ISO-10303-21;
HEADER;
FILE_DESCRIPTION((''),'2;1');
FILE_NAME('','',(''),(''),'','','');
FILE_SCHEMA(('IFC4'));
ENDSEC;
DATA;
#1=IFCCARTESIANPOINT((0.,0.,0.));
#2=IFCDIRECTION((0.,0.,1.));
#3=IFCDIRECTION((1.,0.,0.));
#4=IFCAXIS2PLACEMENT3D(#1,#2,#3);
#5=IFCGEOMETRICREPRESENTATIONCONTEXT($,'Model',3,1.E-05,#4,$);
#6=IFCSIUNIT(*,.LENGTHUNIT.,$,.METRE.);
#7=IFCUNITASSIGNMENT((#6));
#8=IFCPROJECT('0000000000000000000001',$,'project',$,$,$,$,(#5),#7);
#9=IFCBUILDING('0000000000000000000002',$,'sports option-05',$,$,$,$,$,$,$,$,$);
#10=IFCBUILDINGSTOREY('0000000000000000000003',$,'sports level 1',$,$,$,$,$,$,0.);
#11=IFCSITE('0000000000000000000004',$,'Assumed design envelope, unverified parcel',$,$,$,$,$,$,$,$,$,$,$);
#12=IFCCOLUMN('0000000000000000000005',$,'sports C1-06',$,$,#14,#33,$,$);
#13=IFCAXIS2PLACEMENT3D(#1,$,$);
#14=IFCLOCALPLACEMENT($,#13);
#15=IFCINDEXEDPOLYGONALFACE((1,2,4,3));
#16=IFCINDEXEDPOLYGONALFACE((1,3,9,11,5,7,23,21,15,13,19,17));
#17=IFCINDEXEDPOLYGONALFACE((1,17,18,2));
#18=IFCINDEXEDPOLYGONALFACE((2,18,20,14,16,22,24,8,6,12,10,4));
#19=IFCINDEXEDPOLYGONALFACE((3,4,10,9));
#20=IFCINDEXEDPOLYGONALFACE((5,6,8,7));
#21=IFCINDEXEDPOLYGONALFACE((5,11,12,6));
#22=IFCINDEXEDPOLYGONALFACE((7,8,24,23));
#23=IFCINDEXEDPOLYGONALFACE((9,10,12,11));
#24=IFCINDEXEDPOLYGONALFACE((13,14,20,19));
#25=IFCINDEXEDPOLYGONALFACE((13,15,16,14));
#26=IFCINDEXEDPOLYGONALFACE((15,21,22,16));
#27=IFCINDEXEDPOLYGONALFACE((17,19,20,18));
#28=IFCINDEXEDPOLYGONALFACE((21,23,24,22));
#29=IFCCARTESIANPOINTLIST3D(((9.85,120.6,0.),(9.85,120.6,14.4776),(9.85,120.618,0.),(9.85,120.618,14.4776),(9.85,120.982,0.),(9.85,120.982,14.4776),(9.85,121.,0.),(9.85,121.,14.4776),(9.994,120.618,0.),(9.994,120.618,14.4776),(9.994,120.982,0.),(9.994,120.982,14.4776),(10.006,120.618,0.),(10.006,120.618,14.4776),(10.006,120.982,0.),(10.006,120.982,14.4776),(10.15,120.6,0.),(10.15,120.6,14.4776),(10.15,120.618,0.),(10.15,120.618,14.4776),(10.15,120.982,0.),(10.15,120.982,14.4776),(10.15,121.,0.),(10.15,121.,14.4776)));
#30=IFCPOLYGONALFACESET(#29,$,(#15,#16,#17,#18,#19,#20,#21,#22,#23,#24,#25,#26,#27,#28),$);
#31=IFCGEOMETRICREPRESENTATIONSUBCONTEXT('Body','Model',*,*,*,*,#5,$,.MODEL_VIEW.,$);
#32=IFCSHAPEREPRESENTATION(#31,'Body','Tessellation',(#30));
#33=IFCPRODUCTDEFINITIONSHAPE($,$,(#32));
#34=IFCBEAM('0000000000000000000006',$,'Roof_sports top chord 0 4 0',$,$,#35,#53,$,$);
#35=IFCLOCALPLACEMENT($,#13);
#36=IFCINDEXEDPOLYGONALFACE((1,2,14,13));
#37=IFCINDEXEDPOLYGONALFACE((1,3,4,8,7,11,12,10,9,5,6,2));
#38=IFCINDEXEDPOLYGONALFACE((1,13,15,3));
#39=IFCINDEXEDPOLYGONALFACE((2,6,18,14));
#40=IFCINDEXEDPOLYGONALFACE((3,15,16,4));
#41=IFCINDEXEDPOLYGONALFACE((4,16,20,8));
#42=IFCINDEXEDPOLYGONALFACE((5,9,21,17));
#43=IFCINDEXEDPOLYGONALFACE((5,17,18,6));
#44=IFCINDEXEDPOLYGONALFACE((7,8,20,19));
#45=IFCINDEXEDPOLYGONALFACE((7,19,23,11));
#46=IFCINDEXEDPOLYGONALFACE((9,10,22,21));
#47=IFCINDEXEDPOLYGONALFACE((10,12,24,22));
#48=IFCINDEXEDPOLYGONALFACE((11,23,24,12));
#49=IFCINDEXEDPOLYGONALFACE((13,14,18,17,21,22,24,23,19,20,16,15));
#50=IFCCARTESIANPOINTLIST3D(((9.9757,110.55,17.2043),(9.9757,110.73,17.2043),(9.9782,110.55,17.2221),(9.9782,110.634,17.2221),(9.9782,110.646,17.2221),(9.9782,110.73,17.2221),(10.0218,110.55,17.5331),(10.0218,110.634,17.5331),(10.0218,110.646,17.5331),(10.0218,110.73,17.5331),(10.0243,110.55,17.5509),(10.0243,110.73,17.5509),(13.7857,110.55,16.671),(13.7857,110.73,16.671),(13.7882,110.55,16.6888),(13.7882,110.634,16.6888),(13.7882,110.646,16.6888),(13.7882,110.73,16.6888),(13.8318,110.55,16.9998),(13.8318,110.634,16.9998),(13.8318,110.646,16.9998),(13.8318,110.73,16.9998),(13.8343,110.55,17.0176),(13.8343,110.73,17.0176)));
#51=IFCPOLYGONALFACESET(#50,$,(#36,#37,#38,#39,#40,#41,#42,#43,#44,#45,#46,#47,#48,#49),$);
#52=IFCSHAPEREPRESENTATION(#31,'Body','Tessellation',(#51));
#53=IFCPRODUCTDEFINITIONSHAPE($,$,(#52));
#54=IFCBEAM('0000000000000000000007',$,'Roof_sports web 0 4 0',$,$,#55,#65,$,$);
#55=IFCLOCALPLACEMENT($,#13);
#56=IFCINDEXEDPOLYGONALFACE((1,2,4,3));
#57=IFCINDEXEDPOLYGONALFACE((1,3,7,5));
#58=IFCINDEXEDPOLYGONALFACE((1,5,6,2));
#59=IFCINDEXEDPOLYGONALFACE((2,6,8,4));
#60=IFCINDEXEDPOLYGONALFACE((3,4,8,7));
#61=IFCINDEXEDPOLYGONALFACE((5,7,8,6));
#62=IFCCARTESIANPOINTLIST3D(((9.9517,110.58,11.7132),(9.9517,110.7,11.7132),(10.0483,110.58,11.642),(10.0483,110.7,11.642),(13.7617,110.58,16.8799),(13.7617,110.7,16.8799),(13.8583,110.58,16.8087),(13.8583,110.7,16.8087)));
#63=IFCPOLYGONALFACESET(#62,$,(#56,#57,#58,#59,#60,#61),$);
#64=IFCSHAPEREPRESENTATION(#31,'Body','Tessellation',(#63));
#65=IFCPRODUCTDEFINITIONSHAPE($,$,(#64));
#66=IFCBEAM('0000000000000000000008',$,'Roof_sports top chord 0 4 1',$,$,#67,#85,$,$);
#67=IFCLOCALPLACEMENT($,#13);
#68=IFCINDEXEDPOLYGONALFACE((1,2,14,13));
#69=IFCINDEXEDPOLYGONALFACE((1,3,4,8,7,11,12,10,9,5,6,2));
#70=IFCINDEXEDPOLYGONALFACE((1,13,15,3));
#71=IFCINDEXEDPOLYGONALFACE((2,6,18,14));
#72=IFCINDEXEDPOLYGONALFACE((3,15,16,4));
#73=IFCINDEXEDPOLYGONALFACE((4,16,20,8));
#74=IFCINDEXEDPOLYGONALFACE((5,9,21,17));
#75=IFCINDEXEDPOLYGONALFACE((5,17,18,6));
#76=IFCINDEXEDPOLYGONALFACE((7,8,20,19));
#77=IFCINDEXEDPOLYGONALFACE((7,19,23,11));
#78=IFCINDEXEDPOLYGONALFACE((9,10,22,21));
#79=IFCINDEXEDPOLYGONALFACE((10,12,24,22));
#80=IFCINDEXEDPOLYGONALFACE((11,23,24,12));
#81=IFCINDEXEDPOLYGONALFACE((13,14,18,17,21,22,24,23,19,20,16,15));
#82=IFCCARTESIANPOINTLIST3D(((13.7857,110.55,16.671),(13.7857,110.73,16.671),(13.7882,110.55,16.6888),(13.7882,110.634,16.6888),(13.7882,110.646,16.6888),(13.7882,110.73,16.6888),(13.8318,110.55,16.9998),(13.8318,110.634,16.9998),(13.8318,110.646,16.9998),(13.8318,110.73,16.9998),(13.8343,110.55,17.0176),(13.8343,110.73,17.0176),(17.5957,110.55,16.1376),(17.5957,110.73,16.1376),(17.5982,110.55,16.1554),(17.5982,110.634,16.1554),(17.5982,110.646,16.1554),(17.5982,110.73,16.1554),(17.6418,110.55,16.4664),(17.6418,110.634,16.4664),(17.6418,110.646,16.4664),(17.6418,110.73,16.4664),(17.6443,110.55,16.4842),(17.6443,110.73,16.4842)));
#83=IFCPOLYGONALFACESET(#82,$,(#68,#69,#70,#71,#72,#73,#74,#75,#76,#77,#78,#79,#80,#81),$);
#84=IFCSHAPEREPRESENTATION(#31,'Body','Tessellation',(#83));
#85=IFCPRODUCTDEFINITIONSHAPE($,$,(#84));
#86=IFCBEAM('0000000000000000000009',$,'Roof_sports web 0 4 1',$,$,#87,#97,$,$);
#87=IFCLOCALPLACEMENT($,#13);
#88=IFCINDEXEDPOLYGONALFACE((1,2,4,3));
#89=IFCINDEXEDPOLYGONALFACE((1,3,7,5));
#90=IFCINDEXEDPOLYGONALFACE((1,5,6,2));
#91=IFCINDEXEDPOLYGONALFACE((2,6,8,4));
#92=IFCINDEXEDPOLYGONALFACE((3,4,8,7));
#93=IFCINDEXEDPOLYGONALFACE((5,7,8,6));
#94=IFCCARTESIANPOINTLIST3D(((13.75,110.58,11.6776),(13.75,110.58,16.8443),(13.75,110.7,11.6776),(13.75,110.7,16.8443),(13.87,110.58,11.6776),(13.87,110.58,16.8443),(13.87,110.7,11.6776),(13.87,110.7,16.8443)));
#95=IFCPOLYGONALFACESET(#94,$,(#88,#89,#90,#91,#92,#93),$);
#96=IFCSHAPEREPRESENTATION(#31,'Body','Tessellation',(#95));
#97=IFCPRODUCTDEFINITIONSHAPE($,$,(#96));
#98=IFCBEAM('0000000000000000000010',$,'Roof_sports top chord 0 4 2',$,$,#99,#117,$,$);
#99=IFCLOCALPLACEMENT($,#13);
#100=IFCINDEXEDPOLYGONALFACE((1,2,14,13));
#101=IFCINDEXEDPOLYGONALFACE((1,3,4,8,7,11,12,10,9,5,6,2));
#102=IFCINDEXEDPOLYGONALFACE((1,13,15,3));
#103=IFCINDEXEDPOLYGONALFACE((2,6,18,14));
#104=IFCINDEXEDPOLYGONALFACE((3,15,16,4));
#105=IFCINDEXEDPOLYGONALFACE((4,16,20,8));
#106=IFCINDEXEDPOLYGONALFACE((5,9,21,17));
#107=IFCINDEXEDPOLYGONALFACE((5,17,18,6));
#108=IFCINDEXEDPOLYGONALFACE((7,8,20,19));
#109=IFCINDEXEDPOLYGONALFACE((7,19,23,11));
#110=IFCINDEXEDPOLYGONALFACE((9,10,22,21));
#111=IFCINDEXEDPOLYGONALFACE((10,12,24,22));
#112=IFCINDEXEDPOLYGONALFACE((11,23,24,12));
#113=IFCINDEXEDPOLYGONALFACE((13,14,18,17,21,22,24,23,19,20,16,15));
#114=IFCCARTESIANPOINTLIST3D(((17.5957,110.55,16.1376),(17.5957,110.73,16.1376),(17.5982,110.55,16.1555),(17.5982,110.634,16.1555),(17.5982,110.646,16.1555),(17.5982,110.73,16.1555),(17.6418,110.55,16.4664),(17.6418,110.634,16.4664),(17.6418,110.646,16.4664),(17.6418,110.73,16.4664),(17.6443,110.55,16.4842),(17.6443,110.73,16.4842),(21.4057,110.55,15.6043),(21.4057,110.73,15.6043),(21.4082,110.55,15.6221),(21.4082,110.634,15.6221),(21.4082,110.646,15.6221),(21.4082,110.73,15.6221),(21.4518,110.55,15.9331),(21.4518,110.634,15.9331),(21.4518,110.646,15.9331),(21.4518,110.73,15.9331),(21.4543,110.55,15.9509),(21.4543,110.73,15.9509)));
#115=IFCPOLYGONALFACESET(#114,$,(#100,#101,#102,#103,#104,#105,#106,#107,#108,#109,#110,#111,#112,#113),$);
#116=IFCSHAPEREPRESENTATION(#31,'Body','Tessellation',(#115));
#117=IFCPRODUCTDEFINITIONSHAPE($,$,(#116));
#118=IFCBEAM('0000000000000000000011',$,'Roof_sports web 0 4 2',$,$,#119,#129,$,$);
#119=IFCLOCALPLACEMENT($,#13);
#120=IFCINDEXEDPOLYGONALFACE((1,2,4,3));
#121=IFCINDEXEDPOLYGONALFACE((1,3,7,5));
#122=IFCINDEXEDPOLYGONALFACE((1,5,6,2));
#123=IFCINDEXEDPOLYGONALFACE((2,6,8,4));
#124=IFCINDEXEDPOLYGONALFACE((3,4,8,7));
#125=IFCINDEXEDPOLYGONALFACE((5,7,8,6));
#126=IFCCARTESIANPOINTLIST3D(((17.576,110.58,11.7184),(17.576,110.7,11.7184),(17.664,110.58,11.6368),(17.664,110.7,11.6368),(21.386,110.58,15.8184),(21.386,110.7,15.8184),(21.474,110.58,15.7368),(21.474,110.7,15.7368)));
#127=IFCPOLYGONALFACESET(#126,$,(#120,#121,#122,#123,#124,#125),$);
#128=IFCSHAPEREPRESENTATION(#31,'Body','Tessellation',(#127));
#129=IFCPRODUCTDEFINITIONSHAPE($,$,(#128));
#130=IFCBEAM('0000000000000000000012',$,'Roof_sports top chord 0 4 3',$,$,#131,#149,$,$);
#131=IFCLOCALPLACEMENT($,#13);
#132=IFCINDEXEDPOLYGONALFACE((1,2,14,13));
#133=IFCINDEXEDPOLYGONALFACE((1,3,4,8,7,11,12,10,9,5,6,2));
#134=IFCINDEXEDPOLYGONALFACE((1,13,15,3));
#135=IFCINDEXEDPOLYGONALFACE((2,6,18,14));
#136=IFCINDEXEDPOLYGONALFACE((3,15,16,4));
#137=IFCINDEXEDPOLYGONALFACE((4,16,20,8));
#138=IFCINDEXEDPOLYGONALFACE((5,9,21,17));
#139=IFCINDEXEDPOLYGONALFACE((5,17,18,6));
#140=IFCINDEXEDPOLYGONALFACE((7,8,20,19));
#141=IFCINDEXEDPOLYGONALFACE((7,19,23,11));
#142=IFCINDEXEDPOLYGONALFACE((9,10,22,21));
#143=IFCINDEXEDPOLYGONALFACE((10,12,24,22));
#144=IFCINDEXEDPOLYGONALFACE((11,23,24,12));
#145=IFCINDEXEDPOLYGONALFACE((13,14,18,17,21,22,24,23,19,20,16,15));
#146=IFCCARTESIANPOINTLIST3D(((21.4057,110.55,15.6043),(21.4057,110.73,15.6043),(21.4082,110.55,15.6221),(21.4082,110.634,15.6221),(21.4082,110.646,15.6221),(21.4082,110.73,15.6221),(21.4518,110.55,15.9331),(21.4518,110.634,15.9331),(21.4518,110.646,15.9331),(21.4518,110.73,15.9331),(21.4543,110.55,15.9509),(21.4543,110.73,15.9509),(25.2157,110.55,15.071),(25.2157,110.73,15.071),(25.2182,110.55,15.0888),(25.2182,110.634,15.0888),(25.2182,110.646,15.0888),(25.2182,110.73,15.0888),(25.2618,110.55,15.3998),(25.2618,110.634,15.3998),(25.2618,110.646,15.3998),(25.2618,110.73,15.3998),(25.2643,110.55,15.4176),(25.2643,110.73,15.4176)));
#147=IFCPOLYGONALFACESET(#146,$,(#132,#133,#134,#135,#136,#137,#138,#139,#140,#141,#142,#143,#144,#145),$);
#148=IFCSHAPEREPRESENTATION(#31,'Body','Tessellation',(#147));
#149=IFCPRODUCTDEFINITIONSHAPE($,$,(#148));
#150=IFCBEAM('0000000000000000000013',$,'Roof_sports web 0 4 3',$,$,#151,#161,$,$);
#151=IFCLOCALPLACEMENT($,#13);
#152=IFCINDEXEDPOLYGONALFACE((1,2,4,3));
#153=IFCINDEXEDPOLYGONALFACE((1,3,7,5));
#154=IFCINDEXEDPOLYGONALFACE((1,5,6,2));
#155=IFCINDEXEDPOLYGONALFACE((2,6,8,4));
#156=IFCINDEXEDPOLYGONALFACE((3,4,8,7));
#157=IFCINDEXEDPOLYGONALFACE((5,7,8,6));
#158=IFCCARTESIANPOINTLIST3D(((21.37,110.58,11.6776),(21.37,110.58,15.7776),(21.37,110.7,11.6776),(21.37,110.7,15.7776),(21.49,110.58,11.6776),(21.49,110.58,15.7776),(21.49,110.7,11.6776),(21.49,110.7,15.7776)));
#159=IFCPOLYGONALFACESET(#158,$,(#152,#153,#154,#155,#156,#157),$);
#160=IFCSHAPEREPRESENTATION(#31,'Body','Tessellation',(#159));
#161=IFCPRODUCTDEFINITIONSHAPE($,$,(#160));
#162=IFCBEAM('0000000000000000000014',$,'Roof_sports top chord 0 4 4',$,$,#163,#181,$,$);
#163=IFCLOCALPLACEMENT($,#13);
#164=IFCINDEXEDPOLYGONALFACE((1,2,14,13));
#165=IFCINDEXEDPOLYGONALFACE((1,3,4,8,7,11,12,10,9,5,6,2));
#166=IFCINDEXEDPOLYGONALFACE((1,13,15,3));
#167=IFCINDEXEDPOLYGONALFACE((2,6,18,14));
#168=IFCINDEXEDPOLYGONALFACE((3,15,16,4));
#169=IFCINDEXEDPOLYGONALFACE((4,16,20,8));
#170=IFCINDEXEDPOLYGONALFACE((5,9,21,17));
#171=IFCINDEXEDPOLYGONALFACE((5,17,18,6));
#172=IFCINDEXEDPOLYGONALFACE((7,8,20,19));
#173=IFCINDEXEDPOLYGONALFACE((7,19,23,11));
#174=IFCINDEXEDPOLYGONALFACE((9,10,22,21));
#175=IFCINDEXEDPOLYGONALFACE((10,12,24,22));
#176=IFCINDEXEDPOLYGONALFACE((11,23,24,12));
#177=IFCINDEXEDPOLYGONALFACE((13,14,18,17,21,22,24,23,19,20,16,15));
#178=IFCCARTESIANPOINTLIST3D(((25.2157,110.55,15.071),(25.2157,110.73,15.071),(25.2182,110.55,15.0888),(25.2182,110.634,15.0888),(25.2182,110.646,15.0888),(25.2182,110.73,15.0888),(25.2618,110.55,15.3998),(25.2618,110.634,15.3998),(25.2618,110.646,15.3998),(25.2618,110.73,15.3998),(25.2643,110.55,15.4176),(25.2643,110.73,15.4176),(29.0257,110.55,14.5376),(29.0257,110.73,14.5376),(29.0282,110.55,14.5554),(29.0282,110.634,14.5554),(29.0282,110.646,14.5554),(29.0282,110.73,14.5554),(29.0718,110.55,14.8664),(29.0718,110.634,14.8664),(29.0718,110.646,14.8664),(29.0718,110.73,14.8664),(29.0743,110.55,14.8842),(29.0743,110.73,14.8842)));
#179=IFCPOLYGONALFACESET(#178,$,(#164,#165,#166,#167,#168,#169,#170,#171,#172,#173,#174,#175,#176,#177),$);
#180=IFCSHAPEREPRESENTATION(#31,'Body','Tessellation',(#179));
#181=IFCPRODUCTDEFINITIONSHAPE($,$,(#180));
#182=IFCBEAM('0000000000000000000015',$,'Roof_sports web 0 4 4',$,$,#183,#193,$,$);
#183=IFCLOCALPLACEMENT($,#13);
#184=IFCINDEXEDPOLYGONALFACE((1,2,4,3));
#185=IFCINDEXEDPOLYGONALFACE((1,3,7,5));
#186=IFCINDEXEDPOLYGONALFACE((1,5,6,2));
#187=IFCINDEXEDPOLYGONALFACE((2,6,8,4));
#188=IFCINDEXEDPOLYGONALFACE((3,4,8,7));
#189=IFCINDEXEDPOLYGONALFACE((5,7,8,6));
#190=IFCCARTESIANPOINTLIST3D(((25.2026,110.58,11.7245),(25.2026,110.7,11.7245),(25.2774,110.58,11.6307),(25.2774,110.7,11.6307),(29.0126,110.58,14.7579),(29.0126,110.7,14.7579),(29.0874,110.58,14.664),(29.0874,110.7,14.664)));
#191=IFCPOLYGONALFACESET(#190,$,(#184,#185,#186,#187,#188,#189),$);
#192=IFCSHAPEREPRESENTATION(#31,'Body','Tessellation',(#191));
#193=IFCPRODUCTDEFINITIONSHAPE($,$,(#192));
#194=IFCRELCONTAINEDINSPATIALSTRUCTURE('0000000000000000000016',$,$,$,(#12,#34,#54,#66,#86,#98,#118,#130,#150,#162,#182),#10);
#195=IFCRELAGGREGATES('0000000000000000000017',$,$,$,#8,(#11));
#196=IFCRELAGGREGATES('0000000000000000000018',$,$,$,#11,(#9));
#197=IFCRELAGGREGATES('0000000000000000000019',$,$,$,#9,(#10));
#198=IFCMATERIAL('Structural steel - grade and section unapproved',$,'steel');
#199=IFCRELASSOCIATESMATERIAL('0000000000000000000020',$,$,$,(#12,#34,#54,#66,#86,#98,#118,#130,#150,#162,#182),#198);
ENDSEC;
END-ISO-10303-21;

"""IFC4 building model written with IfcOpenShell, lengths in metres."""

from ifc_helpers import new_model, si_unit, frame, origin_with_axes, place, context, subcontext, project, spatial, rectangle, i_section, extrude, material, element, save


model = new_model("IFC4")

# Units and contexts
model_context = context("Model", 3, precision=1e-05, world=origin_with_axes())
body_context = subcontext(model_context, "Body", "Model", "MODEL_VIEW")
ifc_project = project(units=[si_unit("LENGTHUNIT", "METRE")], contexts=[model_context])

# Site, building, storey
site = spatial("IfcSite", under=ifc_project, Name="Assumed design envelope, unverified parcel")
building = spatial("IfcBuilding", under=site, Name="sports option-05")
storey = spatial("IfcBuildingStorey", under=building, Name="sports level 1", Elevation=0.0)

# Column
ifc_material_1 = material(Name="Structural steel - grade and section unapproved", Category="steel")
column_placement = place(None, frame((10.0, 120.8, 0.0), z_axis=(0.0, 0.0, 1.0), x_axis=(-1.0, 0.0, 0.0)))
element("IfcColumn", 1, at=column_placement, inside=storey, material=ifc_material_1, Name="sports C1-06", context=body_context, shape_type="SweptSolid", body=[
    extrude(i_section(OverallWidth=0.3, OverallDepth=0.4, WebThickness=0.012, FlangeThickness=0.018, FilletRadius=0.0), origin_with_axes(), (0.0, 0.0, 1.0), 14.4776),
])

# Beams
beam_1_placement = place(None, frame((10.0, 110.64, 17.3776), z_axis=(0.990344, 0.0, -0.138631), x_axis=(0.0, 1.0, 0.0)))
element("IfcBeam", 2, at=beam_1_placement, inside=storey, material=ifc_material_1, Name="Roof_sports top chord 0 4 0", context=body_context, shape_type="SweptSolid", body=[
    extrude(i_section(OverallWidth=0.18, OverallDepth=0.35, WebThickness=0.012, FlangeThickness=0.018, FilletRadius=0.0), origin_with_axes(), (0.0, 0.0, 1.0), 3.8471),
])
beam_2_placement = place(None, frame((10.0, 110.64, 11.6776), z_axis=(0.5935, 0.0, 0.804834), x_axis=(0.0, 1.0, 0.0)))
element("IfcBeam", 3, at=beam_2_placement, inside=storey, material=ifc_material_1, Name="Roof_sports web 0 4 0", context=body_context, shape_type="SweptSolid", body=[
    extrude(rectangle(XDim=0.12, YDim=0.12), origin_with_axes(), (0.0, 0.0, 1.0), 6.4195),
])
beam_3_placement = place(None, frame((13.81, 110.64, 16.8443), z_axis=(0.990344, 0.0, -0.138631), x_axis=(0.0, 1.0, 0.0)))
element("IfcBeam", 4, at=beam_3_placement, inside=storey, material=ifc_material_1, Name="Roof_sports top chord 0 4 1", context=body_context, shape_type="SweptSolid", body=[
    extrude(i_section(OverallWidth=0.18, OverallDepth=0.35, WebThickness=0.012, FlangeThickness=0.018, FilletRadius=0.0), origin_with_axes(), (0.0, 0.0, 1.0), 3.8471),
])
beam_4_placement = place(None, frame((13.81, 110.64, 11.6776), z_axis=(0.0, 0.0, 1.0), x_axis=(-1.0, 0.0, 0.0)))
element("IfcBeam", 5, at=beam_4_placement, inside=storey, material=ifc_material_1, Name="Roof_sports web 0 4 1", context=body_context, shape_type="SweptSolid", body=[
    extrude(rectangle(XDim=0.12, YDim=0.12), origin_with_axes(), (0.0, 0.0, 1.0), 5.1667),
])
beam_5_placement = place(None, frame((17.62, 110.64, 16.3109), z_axis=(0.990344, 0.0, -0.138631), x_axis=(0.0, 1.0, 0.0)))
element("IfcBeam", 6, at=beam_5_placement, inside=storey, material=ifc_material_1, Name="Roof_sports top chord 0 4 2", context=body_context, shape_type="SweptSolid", body=[
    extrude(i_section(OverallWidth=0.18, OverallDepth=0.35, WebThickness=0.012, FlangeThickness=0.018, FilletRadius=0.0), origin_with_axes(), (0.0, 0.0, 1.0), 3.8471),
])
beam_6_placement = place(None, frame((17.62, 110.64, 11.6776), z_axis=(0.680725, 0.0, 0.732539), x_axis=(0.0, 1.0, 0.0)))
element("IfcBeam", 7, at=beam_6_placement, inside=storey, material=ifc_material_1, Name="Roof_sports web 0 4 2", context=body_context, shape_type="SweptSolid", body=[
    extrude(rectangle(XDim=0.12, YDim=0.12), origin_with_axes(), (0.0, 0.0, 1.0), 5.597),
])
beam_7_placement = place(None, frame((21.43, 110.64, 15.7776), z_axis=(0.990344, 0.0, -0.138631), x_axis=(0.0, 1.0, 0.0)))
element("IfcBeam", 8, at=beam_7_placement, inside=storey, material=ifc_material_1, Name="Roof_sports top chord 0 4 3", context=body_context, shape_type="SweptSolid", body=[
    extrude(i_section(OverallWidth=0.18, OverallDepth=0.35, WebThickness=0.012, FlangeThickness=0.018, FilletRadius=0.0), origin_with_axes(), (0.0, 0.0, 1.0), 3.8471),
])
beam_8_placement = place(None, frame((21.43, 110.64, 11.6776), z_axis=(0.0, 0.0, 1.0), x_axis=(-1.0, 0.0, 0.0)))
element("IfcBeam", 9, at=beam_8_placement, inside=storey, material=ifc_material_1, Name="Roof_sports web 0 4 3", context=body_context, shape_type="SweptSolid", body=[
    extrude(rectangle(XDim=0.12, YDim=0.12), origin_with_axes(), (0.0, 0.0, 1.0), 4.1),
])
beam_9_placement = place(None, frame((25.24, 110.64, 15.2443), z_axis=(0.990344, 0.0, -0.138631), x_axis=(0.0, 1.0, 0.0)))
element("IfcBeam", 10, at=beam_9_placement, inside=storey, material=ifc_material_1, Name="Roof_sports top chord 0 4 4", context=body_context, shape_type="SweptSolid", body=[
    extrude(i_section(OverallWidth=0.18, OverallDepth=0.35, WebThickness=0.012, FlangeThickness=0.018, FilletRadius=0.0), origin_with_axes(), (0.0, 0.0, 1.0), 3.8471),
])
beam_10_placement = place(None, frame((25.24, 110.64, 11.6776), z_axis=(0.782336, 0.0, 0.622857), x_axis=(0.0, 1.0, 0.0)))
element("IfcBeam", 11, at=beam_10_placement, inside=storey, material=ifc_material_1, Name="Roof_sports web 0 4 4", context=body_context, shape_type="SweptSolid", body=[
    extrude(rectangle(XDim=0.12, YDim=0.12), origin_with_axes(), (0.0, 0.0, 1.0), 4.87),
])

save(model, "model.ifc")
